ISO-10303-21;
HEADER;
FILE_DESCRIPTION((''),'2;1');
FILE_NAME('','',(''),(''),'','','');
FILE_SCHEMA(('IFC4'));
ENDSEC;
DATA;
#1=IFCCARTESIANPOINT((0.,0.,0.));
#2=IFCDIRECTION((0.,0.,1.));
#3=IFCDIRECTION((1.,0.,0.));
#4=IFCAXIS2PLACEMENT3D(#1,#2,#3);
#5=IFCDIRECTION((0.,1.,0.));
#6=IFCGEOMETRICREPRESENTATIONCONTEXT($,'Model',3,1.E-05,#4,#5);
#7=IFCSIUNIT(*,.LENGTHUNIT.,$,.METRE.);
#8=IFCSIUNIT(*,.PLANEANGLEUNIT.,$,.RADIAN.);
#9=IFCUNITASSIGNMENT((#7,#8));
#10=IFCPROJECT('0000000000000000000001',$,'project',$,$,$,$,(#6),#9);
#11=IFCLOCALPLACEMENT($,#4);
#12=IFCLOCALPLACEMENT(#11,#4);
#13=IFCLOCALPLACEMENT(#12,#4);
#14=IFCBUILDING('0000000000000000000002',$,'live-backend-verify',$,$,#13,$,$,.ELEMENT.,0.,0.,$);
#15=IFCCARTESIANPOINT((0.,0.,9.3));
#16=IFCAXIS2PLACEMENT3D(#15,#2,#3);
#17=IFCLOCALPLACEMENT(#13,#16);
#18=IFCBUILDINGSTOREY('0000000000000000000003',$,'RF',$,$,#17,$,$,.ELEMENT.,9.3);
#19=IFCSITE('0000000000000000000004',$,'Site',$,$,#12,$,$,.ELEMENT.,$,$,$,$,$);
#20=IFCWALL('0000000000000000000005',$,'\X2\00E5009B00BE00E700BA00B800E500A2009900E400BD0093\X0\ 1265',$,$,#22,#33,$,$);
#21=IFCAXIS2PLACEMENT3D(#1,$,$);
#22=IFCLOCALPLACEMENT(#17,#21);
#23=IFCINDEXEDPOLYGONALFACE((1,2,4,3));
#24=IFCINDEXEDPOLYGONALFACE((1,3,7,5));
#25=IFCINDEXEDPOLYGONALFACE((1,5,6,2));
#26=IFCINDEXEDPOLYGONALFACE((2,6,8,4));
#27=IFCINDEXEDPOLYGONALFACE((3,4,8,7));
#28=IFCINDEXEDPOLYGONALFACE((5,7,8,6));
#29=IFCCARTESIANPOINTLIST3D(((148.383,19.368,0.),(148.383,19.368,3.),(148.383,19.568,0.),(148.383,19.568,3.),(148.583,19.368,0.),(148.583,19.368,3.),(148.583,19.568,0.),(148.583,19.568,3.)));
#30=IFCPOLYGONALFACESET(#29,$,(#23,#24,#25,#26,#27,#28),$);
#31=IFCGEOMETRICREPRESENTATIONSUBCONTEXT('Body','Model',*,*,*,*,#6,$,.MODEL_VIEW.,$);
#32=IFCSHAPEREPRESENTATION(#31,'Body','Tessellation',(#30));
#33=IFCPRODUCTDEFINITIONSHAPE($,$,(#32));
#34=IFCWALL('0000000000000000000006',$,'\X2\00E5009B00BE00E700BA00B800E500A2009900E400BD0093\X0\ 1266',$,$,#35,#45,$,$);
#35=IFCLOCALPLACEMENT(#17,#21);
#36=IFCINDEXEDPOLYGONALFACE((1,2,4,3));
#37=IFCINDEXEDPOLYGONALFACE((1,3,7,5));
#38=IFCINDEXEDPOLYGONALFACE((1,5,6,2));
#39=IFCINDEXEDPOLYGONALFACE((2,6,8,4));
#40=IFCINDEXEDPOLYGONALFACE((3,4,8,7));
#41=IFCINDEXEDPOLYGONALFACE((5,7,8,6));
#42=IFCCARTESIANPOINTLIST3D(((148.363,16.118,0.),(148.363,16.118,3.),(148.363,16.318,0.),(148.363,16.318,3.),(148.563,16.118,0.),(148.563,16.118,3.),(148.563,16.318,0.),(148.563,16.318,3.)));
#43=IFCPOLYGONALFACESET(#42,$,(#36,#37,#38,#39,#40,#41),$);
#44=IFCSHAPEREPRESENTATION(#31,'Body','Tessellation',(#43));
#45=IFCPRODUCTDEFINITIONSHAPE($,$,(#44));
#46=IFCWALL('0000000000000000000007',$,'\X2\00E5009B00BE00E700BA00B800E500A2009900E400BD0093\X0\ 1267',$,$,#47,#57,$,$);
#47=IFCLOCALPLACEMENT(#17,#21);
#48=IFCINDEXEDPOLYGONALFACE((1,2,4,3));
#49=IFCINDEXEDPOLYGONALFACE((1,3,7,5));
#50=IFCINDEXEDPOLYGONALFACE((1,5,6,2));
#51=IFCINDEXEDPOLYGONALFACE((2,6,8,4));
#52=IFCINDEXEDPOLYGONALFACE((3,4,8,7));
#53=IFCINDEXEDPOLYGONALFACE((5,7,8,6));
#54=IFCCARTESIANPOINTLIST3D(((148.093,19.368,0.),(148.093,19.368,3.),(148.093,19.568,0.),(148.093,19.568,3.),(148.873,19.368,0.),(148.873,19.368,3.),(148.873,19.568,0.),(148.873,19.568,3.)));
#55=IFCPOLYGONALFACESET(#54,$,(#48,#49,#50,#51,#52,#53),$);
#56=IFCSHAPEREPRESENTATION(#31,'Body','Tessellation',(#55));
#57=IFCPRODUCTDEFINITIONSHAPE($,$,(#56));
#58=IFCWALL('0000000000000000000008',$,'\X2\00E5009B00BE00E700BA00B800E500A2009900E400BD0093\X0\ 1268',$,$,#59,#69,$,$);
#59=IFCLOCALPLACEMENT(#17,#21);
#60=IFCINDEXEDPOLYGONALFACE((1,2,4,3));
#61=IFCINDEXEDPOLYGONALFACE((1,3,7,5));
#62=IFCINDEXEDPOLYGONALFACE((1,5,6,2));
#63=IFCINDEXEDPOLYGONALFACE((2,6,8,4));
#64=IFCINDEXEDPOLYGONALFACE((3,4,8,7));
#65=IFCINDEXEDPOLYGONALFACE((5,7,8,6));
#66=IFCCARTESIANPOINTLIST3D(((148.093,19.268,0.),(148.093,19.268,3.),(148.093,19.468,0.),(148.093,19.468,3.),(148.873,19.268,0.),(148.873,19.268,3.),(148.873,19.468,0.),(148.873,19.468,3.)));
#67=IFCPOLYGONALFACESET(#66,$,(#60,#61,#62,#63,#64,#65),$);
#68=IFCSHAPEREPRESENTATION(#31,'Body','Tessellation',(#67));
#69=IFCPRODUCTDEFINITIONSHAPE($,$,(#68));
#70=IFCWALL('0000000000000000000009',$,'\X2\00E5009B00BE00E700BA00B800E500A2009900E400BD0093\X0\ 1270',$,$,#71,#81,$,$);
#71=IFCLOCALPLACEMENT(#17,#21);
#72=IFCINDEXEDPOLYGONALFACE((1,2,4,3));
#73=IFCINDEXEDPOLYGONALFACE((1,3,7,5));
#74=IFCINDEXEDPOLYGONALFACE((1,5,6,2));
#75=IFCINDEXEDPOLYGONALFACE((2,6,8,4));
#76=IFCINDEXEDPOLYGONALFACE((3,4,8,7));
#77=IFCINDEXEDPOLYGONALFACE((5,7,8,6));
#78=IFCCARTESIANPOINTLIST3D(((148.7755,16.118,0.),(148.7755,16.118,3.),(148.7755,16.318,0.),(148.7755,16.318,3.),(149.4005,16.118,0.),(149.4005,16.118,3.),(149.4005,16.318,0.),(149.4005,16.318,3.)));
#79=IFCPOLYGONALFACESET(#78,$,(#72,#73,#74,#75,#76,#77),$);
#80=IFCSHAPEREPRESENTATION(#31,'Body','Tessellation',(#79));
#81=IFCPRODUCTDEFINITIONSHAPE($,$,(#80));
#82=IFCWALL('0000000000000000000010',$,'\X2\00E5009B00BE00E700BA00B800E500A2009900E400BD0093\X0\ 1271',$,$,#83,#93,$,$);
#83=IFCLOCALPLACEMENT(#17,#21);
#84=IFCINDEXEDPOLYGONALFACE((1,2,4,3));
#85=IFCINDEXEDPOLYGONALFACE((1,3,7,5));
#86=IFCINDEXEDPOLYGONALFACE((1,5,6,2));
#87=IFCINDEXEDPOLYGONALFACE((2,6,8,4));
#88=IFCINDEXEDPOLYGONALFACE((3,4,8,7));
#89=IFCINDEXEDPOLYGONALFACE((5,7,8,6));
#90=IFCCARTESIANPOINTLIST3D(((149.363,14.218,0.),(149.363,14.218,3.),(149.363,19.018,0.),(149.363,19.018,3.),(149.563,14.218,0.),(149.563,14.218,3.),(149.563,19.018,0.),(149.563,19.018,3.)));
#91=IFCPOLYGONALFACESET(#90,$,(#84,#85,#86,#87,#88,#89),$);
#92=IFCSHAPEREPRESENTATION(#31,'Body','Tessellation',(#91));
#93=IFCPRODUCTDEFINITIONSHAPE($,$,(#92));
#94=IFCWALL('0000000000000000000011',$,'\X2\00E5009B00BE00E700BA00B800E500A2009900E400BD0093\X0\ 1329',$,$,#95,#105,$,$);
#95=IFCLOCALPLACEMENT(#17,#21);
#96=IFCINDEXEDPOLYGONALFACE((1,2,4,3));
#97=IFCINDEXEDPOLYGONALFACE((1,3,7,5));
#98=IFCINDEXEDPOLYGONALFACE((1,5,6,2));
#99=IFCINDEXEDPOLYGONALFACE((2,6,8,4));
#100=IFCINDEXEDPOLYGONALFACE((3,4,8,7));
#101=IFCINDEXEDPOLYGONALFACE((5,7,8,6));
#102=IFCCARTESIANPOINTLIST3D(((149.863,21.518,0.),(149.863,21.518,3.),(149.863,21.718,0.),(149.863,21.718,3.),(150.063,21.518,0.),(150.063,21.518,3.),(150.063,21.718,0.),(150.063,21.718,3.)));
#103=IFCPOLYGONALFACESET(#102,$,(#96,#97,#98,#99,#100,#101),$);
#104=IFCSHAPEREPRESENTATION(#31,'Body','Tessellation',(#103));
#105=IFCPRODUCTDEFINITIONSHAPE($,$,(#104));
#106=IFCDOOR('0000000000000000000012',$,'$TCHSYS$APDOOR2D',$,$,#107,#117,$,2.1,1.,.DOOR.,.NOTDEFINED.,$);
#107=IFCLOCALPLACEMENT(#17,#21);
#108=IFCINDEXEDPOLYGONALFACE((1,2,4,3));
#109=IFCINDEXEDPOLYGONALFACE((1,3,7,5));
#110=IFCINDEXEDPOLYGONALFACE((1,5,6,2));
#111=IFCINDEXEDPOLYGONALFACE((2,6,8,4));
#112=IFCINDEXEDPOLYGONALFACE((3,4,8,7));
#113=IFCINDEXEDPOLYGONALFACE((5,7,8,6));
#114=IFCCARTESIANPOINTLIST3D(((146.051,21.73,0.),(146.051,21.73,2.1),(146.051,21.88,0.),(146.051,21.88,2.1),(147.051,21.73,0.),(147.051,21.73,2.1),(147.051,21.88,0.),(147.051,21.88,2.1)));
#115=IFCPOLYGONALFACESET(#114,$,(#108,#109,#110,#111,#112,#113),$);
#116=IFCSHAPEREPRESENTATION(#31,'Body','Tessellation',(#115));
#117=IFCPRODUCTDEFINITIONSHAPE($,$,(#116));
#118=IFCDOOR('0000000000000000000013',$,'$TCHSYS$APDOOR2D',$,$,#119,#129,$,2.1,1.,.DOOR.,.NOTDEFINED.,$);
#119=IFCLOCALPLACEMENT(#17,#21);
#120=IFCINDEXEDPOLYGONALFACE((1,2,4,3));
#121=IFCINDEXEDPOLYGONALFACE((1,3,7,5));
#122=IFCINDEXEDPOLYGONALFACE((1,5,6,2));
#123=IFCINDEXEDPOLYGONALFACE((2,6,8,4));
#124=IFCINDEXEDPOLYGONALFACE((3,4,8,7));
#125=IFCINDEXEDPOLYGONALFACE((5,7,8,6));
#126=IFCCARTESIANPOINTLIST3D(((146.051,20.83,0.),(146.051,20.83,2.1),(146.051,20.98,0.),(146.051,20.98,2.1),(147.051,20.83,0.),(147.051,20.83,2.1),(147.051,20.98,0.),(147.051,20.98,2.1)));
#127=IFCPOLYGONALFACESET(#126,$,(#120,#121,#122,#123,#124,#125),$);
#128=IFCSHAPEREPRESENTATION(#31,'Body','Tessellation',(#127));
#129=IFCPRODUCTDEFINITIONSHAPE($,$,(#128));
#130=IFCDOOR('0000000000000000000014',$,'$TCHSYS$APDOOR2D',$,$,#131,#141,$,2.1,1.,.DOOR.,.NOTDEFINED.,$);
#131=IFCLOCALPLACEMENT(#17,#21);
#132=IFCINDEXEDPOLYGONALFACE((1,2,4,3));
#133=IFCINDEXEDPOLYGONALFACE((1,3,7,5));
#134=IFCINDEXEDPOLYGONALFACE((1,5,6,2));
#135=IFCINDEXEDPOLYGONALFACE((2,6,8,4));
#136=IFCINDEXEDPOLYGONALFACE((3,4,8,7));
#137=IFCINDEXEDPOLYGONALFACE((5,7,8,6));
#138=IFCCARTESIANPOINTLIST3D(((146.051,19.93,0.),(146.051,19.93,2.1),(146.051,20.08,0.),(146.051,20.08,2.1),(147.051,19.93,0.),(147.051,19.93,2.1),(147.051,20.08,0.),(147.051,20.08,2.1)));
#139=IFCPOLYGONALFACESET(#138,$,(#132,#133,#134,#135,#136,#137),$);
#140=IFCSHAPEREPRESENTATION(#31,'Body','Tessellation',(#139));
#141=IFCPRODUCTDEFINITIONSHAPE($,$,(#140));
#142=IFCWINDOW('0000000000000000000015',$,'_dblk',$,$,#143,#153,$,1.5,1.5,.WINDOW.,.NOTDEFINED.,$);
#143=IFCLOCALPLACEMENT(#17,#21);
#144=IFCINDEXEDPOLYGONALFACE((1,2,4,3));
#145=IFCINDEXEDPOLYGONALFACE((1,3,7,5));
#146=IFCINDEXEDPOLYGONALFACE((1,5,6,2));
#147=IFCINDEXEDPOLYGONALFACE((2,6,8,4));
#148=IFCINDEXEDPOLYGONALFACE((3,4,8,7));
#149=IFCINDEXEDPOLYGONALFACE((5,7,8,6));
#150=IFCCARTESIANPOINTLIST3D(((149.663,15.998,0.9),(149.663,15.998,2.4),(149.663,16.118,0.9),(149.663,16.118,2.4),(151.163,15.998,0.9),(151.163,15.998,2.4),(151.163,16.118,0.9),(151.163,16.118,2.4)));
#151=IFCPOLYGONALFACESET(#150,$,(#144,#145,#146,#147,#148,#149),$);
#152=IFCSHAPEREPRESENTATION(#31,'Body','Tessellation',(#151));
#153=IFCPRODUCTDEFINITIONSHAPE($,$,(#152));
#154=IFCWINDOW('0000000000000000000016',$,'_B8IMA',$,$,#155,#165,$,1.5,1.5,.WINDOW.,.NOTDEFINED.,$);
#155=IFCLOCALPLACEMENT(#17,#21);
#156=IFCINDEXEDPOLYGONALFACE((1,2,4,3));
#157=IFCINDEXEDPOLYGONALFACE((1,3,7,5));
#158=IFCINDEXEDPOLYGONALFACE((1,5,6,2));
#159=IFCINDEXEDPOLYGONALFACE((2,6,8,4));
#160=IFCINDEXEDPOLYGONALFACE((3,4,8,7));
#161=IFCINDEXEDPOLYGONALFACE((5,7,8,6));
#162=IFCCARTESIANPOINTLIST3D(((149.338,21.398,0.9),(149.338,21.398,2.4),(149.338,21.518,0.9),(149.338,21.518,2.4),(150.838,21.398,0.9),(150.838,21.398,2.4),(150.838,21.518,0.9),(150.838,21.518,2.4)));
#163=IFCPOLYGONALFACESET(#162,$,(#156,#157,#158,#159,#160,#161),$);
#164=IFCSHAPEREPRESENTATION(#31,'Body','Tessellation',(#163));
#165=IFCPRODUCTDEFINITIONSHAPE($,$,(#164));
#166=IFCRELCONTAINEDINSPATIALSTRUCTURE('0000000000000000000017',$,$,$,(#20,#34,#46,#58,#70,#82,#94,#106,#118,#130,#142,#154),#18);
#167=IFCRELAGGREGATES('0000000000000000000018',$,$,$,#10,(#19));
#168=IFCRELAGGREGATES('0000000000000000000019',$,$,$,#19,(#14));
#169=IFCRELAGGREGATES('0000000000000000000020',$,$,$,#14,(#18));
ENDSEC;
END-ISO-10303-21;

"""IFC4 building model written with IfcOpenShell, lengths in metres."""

from ifc_helpers import new_model, si_unit, direction, frame, frame_2d, origin_with_axes, place, context, subcontext, project, spatial, rectangle, extrude, element, save


model = new_model("IFC4")

# Units and contexts
model_context = context("Model", 3, precision=1e-05, world=origin_with_axes(), true_north=direction((0.0, 1.0, 0.0)))
body_context = subcontext(model_context, "Body", "Model", "MODEL_VIEW")
ifc_project = project(units=[si_unit("LENGTHUNIT", "METRE"), si_unit("PLANEANGLEUNIT", "RADIAN")], contexts=[model_context])

# Site, building, storey
placement = place(None, origin_with_axes())
site_placement = place(placement, origin_with_axes())
site = spatial("IfcSite", under=ifc_project, at=site_placement, Name="Site", CompositionType="ELEMENT")
building_placement = place(site_placement, origin_with_axes())
building = spatial("IfcBuilding", under=site, at=building_placement, Name="live-backend-verify", CompositionType="ELEMENT", ElevationOfRefHeight=0.0, ElevationOfTerrain=0.0)
storey_placement = place(building_placement, frame((0.0, 0.0, 9.3), z_axis=(0.0, 0.0, 1.0), x_axis=(1.0, 0.0, 0.0)))
storey = spatial("IfcBuildingStorey", under=building, at=storey_placement, Name="RF", CompositionType="ELEMENT", Elevation=9.3)

# Walls
for number, where, z_axis, x_axis, name in (
    (1, (148.483, 19.468, 0.0), (0.0, 0.0, 1.0), (0.0, -1.0, 0.0), "å\u009b¾çº¸å¢\u0099ä½\u0093 1265"),
    (2, (148.463, 16.218, 0.0), (0.0, 0.0, 1.0), (0.0, -1.0, 0.0), "å\u009b¾çº¸å¢\u0099ä½\u0093 1266"),
):
    element("IfcWall", number, at=place(storey_placement, frame(where, z_axis=z_axis, x_axis=x_axis)), inside=storey, Name=name, context=body_context, shape_type="SweptSolid", body=[
        extrude(rectangle(XDim=0.2, YDim=0.2, at=frame_2d((0.0, 0.0), x_axis=(1.0, 0.0, 0.0))), frame((0.0, 0.0, 0.0), z_axis=(0.0, 0.0, 1.0)), (0.0, 0.0, 1.0), 3.0),
    ])
for number, where, z_axis, x_axis, name in (
    (3, (148.483, 19.468, 0.0), (0.0, 0.0, 1.0), (1.0, 0.0, 0.0), "å\u009b¾çº¸å¢\u0099ä½\u0093 1267"),
    (4, (148.483, 19.368, 0.0), (0.0, 0.0, 1.0), (1.0, 0.0, 0.0), "å\u009b¾çº¸å¢\u0099ä½\u0093 1268"),
):
    element("IfcWall", number, at=place(storey_placement, frame(where, z_axis=z_axis, x_axis=x_axis)), inside=storey, Name=name, context=body_context, shape_type="SweptSolid", body=[
        extrude(rectangle(XDim=0.78, YDim=0.2, at=frame_2d((0.0, 0.0), x_axis=(1.0, 0.0, 0.0))), frame((0.0, 0.0, 0.0), z_axis=(0.0, 0.0, 1.0)), (0.0, 0.0, 1.0), 3.0),
    ])
wall_1_placement = place(storey_placement, frame((149.088, 16.218, 0.0), z_axis=(0.0, 0.0, 1.0), x_axis=(-1.0, 0.0, 0.0)))
element("IfcWall", 5, at=wall_1_placement, inside=storey, Name="å\u009b¾çº¸å¢\u0099ä½\u0093 1270", context=body_context, shape_type="SweptSolid", body=[
    extrude(rectangle(XDim=0.625, YDim=0.2, at=frame_2d((0.0, 0.0), x_axis=(1.0, 0.0, 0.0))), frame((0.0, 0.0, 0.0), z_axis=(0.0, 0.0, 1.0)), (0.0, 0.0, 1.0), 3.0),
])
wall_2_placement = place(storey_placement, frame((149.463, 16.618, 0.0), z_axis=(0.0, 0.0, 1.0), x_axis=(0.0, 1.0, 0.0)))
element("IfcWall", 6, at=wall_2_placement, inside=storey, Name="å\u009b¾çº¸å¢\u0099ä½\u0093 1271", context=body_context, shape_type="SweptSolid", body=[
    extrude(rectangle(XDim=4.8, YDim=0.2, at=frame_2d((0.0, 0.0), x_axis=(1.0, 0.0, 0.0))), frame((0.0, 0.0, 0.0), z_axis=(0.0, 0.0, 1.0)), (0.0, 0.0, 1.0), 3.0),
])
wall_3_placement = place(storey_placement, frame((149.963, 21.618, 0.0), z_axis=(0.0, 0.0, 1.0), x_axis=(0.0, -1.0, 0.0)))
element("IfcWall", 7, at=wall_3_placement, inside=storey, Name="å\u009b¾çº¸å¢\u0099ä½\u0093 1329", context=body_context, shape_type="SweptSolid", body=[
    extrude(rectangle(XDim=0.2, YDim=0.2, at=frame_2d((0.0, 0.0), x_axis=(1.0, 0.0, 0.0))), frame((0.0, 0.0, 0.0), z_axis=(0.0, 0.0, 1.0)), (0.0, 0.0, 1.0), 3.0),
])

# Doors
for number, where, z_axis, x_axis, name in (
    (8, (146.551, 21.805, 0.0), (0.0, 0.0, 1.0), (1.0, 0.0, 0.0), "$TCHSYS$APDOOR2D"),
    (9, (146.551, 20.905, 0.0), (0.0, 0.0, 1.0), (1.0, 0.0, 0.0), "$TCHSYS$APDOOR2D"),
    (10, (146.551, 20.005, 0.0), (0.0, 0.0, 1.0), (1.0, 0.0, 0.0), "$TCHSYS$APDOOR2D"),
):
    element("IfcDoor", number, at=place(storey_placement, frame(where, z_axis=z_axis, x_axis=x_axis)), inside=storey, Name=name, OperationType="NOTDEFINED", OverallHeight=2.1, OverallWidth=1.0, PredefinedType="DOOR", context=body_context, shape_type="SweptSolid", body=[
        extrude(rectangle(XDim=1.0, YDim=0.15, at=frame_2d((0.0, 0.0), x_axis=(1.0, 0.0, 0.0))), frame((0.0, 0.0, 0.0), z_axis=(0.0, 0.0, 1.0)), (0.0, 0.0, 1.0), 2.1),
    ])

# Windows
for number, where, z_axis, x_axis, name in (
    (11, (150.413, 16.058, 0.9), (0.0, 0.0, 1.0), (1.0, 0.0, 0.0), "_dblk"),
    (12, (150.088, 21.458, 0.9), (0.0, 0.0, 1.0), (1.0, 0.0, 0.0), "_B8IMA"),
):
    element("IfcWindow", number, at=place(storey_placement, frame(where, z_axis=z_axis, x_axis=x_axis)), inside=storey, Name=name, OverallHeight=1.5, OverallWidth=1.5, PartitioningType="NOTDEFINED", PredefinedType="WINDOW", context=body_context, shape_type="SweptSolid", body=[
        extrude(rectangle(XDim=1.5, YDim=0.12, at=frame_2d((0.0, 0.0), x_axis=(1.0, 0.0, 0.0))), frame((0.0, 0.0, 0.0), z_axis=(0.0, 0.0, 1.0)), (0.0, 0.0, 1.0), 1.5),
    ])

save(model, "model.ifc")
